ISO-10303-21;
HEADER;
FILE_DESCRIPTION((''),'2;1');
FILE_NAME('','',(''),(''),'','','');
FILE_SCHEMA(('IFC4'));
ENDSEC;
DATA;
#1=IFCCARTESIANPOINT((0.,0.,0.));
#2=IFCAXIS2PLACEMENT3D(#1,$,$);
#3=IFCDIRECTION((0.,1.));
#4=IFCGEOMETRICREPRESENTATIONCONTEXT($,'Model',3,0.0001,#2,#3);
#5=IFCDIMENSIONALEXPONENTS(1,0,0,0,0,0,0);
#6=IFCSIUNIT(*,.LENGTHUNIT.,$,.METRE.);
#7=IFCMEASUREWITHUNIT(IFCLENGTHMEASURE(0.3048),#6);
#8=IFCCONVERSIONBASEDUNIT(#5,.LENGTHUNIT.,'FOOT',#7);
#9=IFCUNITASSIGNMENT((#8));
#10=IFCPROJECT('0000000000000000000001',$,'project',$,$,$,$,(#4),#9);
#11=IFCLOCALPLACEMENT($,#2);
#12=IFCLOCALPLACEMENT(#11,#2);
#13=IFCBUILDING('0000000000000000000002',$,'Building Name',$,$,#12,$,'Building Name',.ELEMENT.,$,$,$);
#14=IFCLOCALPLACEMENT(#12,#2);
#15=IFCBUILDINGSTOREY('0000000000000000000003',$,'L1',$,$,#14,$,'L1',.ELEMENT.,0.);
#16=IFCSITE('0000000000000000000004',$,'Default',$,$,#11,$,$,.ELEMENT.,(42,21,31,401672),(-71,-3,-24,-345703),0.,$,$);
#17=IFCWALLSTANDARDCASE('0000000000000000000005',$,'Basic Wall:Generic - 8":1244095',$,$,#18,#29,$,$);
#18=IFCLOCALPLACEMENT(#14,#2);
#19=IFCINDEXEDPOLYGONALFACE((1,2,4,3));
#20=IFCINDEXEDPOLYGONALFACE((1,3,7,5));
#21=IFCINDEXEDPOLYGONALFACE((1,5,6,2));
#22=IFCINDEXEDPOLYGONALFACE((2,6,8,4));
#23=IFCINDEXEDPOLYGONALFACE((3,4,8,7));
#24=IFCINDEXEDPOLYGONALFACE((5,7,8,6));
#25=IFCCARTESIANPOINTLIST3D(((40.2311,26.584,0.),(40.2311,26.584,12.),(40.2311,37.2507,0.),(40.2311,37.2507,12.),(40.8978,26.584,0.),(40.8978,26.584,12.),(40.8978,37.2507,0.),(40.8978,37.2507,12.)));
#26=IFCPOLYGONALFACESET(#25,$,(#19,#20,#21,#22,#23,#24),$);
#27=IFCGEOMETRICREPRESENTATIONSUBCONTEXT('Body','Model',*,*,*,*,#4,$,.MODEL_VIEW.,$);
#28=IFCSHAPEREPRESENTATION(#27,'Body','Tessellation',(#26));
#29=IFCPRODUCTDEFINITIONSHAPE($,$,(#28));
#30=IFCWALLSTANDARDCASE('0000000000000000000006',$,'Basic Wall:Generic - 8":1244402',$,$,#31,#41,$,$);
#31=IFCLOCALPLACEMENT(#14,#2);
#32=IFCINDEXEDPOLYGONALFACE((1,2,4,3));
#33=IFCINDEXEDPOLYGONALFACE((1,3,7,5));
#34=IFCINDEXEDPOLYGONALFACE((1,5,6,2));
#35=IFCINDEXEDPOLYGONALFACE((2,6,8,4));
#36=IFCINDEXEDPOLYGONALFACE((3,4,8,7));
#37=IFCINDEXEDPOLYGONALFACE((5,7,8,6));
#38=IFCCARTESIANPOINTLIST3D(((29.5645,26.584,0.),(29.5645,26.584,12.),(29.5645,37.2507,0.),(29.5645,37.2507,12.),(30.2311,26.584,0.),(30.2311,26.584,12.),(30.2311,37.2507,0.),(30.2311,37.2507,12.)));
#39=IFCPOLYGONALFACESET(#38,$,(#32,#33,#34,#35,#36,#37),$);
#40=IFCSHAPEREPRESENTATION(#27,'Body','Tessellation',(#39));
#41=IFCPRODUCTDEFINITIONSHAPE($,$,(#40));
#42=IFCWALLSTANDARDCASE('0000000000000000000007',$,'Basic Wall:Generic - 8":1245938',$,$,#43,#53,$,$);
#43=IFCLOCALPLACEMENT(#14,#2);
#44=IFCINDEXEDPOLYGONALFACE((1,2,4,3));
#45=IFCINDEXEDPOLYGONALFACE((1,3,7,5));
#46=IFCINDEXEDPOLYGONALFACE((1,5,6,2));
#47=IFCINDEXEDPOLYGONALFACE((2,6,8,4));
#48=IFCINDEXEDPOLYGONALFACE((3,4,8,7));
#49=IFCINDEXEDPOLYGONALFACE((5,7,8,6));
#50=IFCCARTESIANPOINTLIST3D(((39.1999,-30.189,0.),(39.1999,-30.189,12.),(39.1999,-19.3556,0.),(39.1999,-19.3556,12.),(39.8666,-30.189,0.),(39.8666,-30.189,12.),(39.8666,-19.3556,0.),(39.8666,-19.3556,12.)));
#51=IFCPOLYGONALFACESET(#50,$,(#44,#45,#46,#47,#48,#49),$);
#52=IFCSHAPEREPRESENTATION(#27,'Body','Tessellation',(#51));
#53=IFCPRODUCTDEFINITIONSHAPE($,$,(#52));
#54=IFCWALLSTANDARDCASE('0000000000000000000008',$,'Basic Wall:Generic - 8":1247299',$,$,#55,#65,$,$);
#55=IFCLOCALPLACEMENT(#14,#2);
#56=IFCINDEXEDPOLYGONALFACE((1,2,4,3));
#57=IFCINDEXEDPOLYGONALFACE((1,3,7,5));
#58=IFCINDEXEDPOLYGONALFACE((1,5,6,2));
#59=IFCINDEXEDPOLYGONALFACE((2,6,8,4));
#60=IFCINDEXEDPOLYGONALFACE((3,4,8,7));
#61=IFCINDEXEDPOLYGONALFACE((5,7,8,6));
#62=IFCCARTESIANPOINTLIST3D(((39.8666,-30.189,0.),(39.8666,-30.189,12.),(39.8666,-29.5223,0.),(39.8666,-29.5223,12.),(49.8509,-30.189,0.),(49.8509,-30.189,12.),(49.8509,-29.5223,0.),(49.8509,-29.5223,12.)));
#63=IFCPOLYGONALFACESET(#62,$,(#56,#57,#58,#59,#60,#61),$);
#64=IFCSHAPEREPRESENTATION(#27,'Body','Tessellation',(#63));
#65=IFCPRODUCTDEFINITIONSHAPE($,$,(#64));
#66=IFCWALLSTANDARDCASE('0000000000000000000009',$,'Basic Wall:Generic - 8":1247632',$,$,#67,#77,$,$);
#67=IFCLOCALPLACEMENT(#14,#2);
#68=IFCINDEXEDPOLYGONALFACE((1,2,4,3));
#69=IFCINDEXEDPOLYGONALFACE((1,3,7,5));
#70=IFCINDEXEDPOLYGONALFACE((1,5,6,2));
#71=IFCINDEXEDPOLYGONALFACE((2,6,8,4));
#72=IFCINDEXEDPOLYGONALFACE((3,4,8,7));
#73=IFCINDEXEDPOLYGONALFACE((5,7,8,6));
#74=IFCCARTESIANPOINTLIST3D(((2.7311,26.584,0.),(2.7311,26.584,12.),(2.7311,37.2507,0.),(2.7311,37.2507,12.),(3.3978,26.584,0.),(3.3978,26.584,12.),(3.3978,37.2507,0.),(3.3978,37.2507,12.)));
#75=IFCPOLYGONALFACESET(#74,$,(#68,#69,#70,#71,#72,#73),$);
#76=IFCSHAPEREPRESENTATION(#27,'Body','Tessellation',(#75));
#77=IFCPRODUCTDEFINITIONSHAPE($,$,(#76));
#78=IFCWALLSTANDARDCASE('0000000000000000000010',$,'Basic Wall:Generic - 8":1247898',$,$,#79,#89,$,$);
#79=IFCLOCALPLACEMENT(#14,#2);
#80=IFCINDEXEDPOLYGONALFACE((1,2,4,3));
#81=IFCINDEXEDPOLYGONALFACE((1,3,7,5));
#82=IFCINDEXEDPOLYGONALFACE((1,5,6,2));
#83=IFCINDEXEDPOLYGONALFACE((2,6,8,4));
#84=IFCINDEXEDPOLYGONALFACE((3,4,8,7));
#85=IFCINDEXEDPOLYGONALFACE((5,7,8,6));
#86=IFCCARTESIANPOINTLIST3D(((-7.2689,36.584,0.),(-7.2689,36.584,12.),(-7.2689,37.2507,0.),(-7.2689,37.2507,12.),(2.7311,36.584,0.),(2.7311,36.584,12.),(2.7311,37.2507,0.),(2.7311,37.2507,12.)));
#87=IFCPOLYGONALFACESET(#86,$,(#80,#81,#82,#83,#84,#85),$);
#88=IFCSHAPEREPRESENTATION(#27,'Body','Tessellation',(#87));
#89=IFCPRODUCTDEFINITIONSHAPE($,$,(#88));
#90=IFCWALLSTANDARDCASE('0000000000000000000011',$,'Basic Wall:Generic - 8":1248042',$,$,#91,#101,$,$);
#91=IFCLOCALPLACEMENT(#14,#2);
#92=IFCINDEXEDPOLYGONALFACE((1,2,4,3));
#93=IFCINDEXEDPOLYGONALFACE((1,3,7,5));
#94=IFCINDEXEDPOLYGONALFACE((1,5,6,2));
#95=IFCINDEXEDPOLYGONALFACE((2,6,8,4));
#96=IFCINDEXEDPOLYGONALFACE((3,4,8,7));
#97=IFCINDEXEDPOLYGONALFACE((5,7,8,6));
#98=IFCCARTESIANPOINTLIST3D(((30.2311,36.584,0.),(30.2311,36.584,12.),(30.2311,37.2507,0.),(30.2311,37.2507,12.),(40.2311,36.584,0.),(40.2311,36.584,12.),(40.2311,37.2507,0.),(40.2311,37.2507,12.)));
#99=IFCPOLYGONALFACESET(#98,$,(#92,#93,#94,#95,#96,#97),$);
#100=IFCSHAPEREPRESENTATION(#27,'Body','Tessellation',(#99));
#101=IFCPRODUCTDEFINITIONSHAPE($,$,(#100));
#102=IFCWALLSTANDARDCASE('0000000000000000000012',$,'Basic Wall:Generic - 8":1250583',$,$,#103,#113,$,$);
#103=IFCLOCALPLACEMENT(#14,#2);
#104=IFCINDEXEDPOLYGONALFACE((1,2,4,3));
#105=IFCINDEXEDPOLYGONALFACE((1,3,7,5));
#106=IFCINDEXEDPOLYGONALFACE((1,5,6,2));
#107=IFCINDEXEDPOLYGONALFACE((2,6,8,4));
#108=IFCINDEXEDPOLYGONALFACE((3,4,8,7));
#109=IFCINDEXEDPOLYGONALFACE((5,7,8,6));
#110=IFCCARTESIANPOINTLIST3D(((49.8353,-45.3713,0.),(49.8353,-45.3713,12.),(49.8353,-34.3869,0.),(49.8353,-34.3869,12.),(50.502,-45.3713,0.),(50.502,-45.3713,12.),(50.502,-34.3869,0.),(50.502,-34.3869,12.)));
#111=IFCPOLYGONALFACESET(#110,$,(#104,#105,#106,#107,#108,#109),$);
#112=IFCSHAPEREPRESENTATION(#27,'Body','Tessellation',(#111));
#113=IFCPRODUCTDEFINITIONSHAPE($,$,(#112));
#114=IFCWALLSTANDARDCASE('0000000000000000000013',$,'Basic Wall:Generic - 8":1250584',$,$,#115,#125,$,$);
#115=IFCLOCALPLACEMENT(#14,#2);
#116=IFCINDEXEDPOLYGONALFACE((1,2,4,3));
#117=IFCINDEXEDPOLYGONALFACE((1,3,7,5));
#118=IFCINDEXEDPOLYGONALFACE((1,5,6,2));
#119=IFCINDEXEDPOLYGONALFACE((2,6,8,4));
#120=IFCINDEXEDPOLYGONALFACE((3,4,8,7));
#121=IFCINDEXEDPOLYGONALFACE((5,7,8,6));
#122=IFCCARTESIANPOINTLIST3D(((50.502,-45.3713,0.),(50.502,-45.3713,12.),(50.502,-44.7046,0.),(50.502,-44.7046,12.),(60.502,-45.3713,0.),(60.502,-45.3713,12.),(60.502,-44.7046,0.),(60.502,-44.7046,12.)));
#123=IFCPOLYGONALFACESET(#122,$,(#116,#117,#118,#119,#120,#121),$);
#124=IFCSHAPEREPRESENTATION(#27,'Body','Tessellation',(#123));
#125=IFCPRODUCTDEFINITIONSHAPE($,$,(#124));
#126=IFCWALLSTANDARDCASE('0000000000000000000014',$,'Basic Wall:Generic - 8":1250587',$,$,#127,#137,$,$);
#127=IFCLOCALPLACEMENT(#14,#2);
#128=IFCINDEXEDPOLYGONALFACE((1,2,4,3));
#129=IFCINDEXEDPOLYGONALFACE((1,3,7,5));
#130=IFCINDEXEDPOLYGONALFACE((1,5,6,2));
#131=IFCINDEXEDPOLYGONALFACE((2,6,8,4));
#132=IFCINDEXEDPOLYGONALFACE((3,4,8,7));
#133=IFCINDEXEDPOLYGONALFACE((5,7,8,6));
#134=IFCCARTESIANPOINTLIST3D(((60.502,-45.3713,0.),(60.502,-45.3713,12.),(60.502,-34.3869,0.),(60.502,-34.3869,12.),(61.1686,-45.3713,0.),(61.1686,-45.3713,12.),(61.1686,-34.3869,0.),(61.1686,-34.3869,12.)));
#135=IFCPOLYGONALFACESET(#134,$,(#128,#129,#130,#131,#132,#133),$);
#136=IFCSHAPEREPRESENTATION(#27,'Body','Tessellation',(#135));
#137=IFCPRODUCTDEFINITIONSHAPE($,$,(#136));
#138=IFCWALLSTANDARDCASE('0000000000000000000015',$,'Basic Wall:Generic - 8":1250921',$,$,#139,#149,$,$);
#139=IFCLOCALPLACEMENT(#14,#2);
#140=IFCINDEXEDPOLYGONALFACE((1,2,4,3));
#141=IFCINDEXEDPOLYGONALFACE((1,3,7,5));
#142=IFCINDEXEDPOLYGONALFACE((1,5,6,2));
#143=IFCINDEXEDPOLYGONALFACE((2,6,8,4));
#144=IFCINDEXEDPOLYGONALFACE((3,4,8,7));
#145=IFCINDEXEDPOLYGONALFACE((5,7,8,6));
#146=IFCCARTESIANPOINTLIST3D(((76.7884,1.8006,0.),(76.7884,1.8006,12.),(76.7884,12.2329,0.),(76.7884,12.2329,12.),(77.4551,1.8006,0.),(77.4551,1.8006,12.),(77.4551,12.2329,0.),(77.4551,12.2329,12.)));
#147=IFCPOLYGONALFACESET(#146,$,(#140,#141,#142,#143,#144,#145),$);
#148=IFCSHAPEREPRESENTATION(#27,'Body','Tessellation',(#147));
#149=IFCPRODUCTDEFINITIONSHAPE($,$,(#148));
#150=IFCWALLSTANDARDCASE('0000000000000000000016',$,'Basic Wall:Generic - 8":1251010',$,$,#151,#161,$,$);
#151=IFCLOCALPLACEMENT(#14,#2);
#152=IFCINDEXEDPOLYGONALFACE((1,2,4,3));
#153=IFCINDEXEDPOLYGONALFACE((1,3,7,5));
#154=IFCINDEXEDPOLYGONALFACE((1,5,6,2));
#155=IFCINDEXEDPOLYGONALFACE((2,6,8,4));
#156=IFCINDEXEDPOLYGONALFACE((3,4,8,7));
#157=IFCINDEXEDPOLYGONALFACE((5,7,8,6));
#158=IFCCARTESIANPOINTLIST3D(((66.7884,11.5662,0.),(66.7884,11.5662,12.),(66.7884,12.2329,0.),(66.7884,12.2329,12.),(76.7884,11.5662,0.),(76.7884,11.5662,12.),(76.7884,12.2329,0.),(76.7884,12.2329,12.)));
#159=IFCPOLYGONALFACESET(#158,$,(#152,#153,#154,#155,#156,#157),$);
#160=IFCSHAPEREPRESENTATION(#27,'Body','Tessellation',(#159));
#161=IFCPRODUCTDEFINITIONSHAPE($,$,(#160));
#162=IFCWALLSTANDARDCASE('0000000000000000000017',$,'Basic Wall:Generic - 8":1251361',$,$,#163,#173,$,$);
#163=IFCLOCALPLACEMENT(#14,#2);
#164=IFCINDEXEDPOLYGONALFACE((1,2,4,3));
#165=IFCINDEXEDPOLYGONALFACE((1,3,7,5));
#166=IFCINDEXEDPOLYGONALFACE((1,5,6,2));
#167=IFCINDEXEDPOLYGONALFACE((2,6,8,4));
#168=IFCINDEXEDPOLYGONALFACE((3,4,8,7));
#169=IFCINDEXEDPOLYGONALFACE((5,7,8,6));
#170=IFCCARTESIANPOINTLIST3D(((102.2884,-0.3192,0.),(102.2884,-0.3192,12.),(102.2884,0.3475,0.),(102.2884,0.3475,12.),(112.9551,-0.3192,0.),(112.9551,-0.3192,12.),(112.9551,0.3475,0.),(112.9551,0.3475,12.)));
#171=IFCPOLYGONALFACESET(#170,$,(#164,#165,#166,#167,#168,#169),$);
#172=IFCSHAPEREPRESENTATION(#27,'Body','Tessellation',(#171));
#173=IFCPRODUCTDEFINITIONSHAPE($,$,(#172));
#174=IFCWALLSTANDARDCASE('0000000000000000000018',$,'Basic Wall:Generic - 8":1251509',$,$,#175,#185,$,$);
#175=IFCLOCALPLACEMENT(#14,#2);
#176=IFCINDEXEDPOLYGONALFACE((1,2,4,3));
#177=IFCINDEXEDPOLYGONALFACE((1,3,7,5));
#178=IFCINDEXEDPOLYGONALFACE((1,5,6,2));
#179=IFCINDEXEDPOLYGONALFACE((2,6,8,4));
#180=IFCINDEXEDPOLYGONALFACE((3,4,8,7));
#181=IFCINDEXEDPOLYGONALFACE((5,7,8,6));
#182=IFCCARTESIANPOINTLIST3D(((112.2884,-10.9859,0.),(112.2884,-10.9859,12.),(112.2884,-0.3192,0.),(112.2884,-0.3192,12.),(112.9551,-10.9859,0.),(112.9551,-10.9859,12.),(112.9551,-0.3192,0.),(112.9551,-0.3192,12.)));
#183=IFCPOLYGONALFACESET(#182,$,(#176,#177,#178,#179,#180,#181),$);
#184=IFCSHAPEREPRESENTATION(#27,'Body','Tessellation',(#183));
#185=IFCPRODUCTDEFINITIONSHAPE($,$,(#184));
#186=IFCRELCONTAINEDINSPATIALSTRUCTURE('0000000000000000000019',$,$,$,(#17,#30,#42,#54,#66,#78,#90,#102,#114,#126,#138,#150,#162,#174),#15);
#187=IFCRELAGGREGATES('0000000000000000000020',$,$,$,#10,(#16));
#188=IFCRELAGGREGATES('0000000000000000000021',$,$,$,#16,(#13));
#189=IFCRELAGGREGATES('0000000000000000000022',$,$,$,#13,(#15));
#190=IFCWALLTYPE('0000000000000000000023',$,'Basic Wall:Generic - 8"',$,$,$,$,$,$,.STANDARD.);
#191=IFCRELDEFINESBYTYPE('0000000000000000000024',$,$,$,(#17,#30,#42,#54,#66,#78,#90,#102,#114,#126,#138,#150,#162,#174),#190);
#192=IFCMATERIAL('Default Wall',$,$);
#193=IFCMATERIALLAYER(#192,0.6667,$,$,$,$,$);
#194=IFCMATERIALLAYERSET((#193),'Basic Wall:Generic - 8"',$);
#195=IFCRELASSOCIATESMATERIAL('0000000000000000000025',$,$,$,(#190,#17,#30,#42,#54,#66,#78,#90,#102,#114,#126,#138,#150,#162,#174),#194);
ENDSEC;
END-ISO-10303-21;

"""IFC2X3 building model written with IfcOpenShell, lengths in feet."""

from ifc_helpers import new_model, entity, si_unit, converted_unit, direction, frame, frame_2d, origin, place, context, subcontext, project, spatial, rectangle, extrude, material, layer, layer_set, layer_usage, type_object, element, save


model = new_model("IFC2X3")

# Units and contexts
model_context = context("Model", 3, precision=0.0001, world=origin(), true_north=direction((0.0, 1.0)))
body_context = subcontext(model_context, "Body", "Model", "MODEL_VIEW")
ifc_project = project(units=[converted_unit("LENGTHUNIT", "FOOT", entity("IfcLengthMeasure", 0.3048), si_unit("LENGTHUNIT", "METRE"), dimensions=[1, 0, 0, 0, 0, 0, 0])], contexts=[model_context])

# Site, building, storey
site_placement = place(None, origin())
site = spatial("IfcSite", under=ifc_project, at=site_placement, Name="Default", CompositionType="ELEMENT", RefLatitude=(42, 21, 31, 401672), RefLongitude=(-71, -3, -24, -345703), RefElevation=0.0)
building_placement = place(site_placement, origin())
building = spatial("IfcBuilding", under=site, at=building_placement, Name="Building Name", LongName="Building Name", CompositionType="ELEMENT")
storey_placement = place(building_placement, origin())
storey = spatial("IfcBuildingStorey", under=building, at=storey_placement, Name="L1", LongName="L1", CompositionType="ELEMENT", Elevation=0.0)

# Walls
ifc_material_1 = material(Name="Default Wall")
ifc_layer_1 = layer(ifc_material_1, 0.6667)
ifc_layer_set_1 = layer_set([ifc_layer_1], Name="Basic Wall:Generic - 8\"")
ifc_layer_usage_1 = layer_usage(ifc_layer_set_1, "AXIS2", "POSITIVE", -0.3333)
wall_type_1 = type_object("IfcWallType", Name="Basic Wall:Generic - 8\"", PredefinedType="STANDARD", material=ifc_layer_set_1)
wall_1_placement = place(storey_placement, frame((40.5645, 26.584, 0.0), z_axis=(0.0, 0.0, 1.0), x_axis=(0.0, 1.0, 0.0)))
element("IfcWallStandardCase", 1, at=wall_1_placement, inside=storey, type_object=wall_type_1, material=ifc_layer_usage_1, Name="Basic Wall:Generic - 8\":1244095", context=body_context, shape_type="SweptSolid", body=[
    extrude(rectangle(XDim=10.6667, YDim=0.6667, at=frame_2d((5.3333, 0.0), x_axis=(-1.0, 0.0))), origin(), (0.0, 0.0, 1.0), 12.0),
])
ifc_layer_usage_2 = layer_usage(ifc_layer_set_1, "AXIS2", "NEGATIVE", 0.3333)
wall_2_placement = place(storey_placement, frame((29.8978, 26.584, 0.0), z_axis=(0.0, 0.0, 1.0), x_axis=(0.0, 1.0, 0.0)))
element("IfcWallStandardCase", 2, at=wall_2_placement, inside=storey, type_object=wall_type_1, material=ifc_layer_usage_2, Name="Basic Wall:Generic - 8\":1244402", context=body_context, shape_type="SweptSolid", body=[
    extrude(rectangle(XDim=10.6667, YDim=0.6667, at=frame_2d((5.3333, 0.0), x_axis=(-1.0, 0.0))), origin(), (0.0, 0.0, 1.0), 12.0),
])
ifc_layer_usage_3 = layer_usage(ifc_layer_set_1, "AXIS2", "POSITIVE", -0.3333)
wall_3_placement = place(storey_placement, frame((39.5332, -19.3556, 0.0), z_axis=(0.0, 0.0, 1.0), x_axis=(0.0, -1.0, 0.0)))
element("IfcWallStandardCase", 3, at=wall_3_placement, inside=storey, type_object=wall_type_1, material=ifc_layer_usage_3, Name="Basic Wall:Generic - 8\":1245938", context=body_context, shape_type="SweptSolid", body=[
    extrude(rectangle(XDim=10.8333, YDim=0.6667, at=frame_2d((5.4167, 0.0), x_axis=(-1.0, 0.0))), origin(), (0.0, 0.0, 1.0), 12.0),
])
ifc_layer_usage_4 = layer_usage(ifc_layer_set_1, "AXIS2", "NEGATIVE", 0.3333)
wall_4_placement = place(storey_placement, frame((39.8666, -29.8556, 0.0)))
element("IfcWallStandardCase", 4, at=wall_4_placement, inside=storey, type_object=wall_type_1, material=ifc_layer_usage_4, Name="Basic Wall:Generic - 8\":1247299", context=body_context, shape_type="SweptSolid", body=[
    extrude(rectangle(XDim=9.9844, YDim=0.6667, at=frame_2d((4.9922, 0.0), x_axis=(-1.0, 0.0))), origin(), (0.0, 0.0, 1.0), 12.0),
])
ifc_layer_usage_5 = layer_usage(ifc_layer_set_1, "AXIS2", "NEGATIVE", 0.3333)
wall_5_placement = place(storey_placement, frame((3.0645, 37.2507, 0.0), z_axis=(0.0, 0.0, 1.0), x_axis=(0.0, -1.0, 0.0)))
element("IfcWallStandardCase", 5, at=wall_5_placement, inside=storey, type_object=wall_type_1, material=ifc_layer_usage_5, Name="Basic Wall:Generic - 8\":1247632", context=body_context, shape_type="SweptSolid", body=[
    extrude(rectangle(XDim=10.6667, YDim=0.6667, at=frame_2d((5.3333, 0.0), x_axis=(-1.0, 0.0))), origin(), (0.0, 0.0, 1.0), 12.0),
])
ifc_layer_usage_6 = layer_usage(ifc_layer_set_1, "AXIS2", "NEGATIVE", 0.3333)
wall_6_placement = place(storey_placement, frame((-7.2689, 36.9174, 0.0)))
element("IfcWallStandardCase", 6, at=wall_6_placement, inside=storey, type_object=wall_type_1, material=ifc_layer_usage_6, Name="Basic Wall:Generic - 8\":1247898", context=body_context, shape_type="SweptSolid", body=[
    extrude(rectangle(XDim=10.0, YDim=0.6667, at=frame_2d((5.0, 0.0), x_axis=(-1.0, 0.0))), origin(), (0.0, 0.0, 1.0), 12.0),
])
ifc_layer_usage_7 = layer_usage(ifc_layer_set_1, "AXIS2", "NEGATIVE", 0.3333)
wall_7_placement = place(storey_placement, frame((30.2311, 36.9174, 0.0)))
element("IfcWallStandardCase", 7, at=wall_7_placement, inside=storey, type_object=wall_type_1, material=ifc_layer_usage_7, Name="Basic Wall:Generic - 8\":1248042", context=body_context, shape_type="SweptSolid", body=[
    extrude(rectangle(XDim=10.0, YDim=0.6667, at=frame_2d((5.0, 0.0), x_axis=(-1.0, 0.0))), origin(), (0.0, 0.0, 1.0), 12.0),
])
ifc_layer_usage_8 = layer_usage(ifc_layer_set_1, "AXIS2", "POSITIVE", -0.3333)
wall_8_placement = place(storey_placement, frame((50.1686, -34.3869, 0.0), z_axis=(0.0, 0.0, 1.0), x_axis=(0.0, -1.0, 0.0)))
element("IfcWallStandardCase", 8, at=wall_8_placement, inside=storey, type_object=wall_type_1, material=ifc_layer_usage_8, Name="Basic Wall:Generic - 8\":1250583", context=body_context, shape_type="SweptSolid", body=[
    extrude(rectangle(XDim=10.9844, YDim=0.6667, at=frame_2d((5.4922, 0.0), x_axis=(-1.0, 0.0))), origin(), (0.0, 0.0, 1.0), 12.0),
])
ifc_layer_usage_9 = layer_usage(ifc_layer_set_1, "AXIS2", "POSITIVE", -0.3333)
wall_9_placement = place(storey_placement, frame((50.502, -45.0379, 0.0)))
element("IfcWallStandardCase", 9, at=wall_9_placement, inside=storey, type_object=wall_type_1, material=ifc_layer_usage_9, Name="Basic Wall:Generic - 8\":1250584", context=body_context, shape_type="SweptSolid", body=[
    extrude(rectangle(XDim=10.0, YDim=0.6667, at=frame_2d((5.0, 0.0), x_axis=(-1.0, 0.0))), origin(), (0.0, 0.0, 1.0), 12.0),
])
ifc_layer_usage_10 = layer_usage(ifc_layer_set_1, "AXIS2", "NEGATIVE", 0.3333)
wall_10_placement = place(storey_placement, frame((60.8353, -34.3869, 0.0), z_axis=(0.0, 0.0, 1.0), x_axis=(0.0, -1.0, 0.0)))
element("IfcWallStandardCase", 10, at=wall_10_placement, inside=storey, type_object=wall_type_1, material=ifc_layer_usage_10, Name="Basic Wall:Generic - 8\":1250587", context=body_context, shape_type="SweptSolid", body=[
    extrude(rectangle(XDim=10.9844, YDim=0.6667, at=frame_2d((5.4922, 0.0), x_axis=(-1.0, 0.0))), origin(), (0.0, 0.0, 1.0), 12.0),
])
ifc_layer_usage_11 = layer_usage(ifc_layer_set_1, "AXIS2", "NEGATIVE", 0.3333)
wall_11_placement = place(storey_placement, frame((77.1218, 1.8006, 0.0), z_axis=(0.0, 0.0, 1.0), x_axis=(0.0, 1.0, 0.0)))
element("IfcWallStandardCase", 11, at=wall_11_placement, inside=storey, type_object=wall_type_1, material=ifc_layer_usage_11, Name="Basic Wall:Generic - 8\":1250921", context=body_context, shape_type="SweptSolid", body=[
    extrude(rectangle(XDim=10.4323, YDim=0.6667, at=frame_2d((5.2161, 0.0), x_axis=(-1.0, 0.0))), origin(), (0.0, 0.0, 1.0), 12.0),
])
ifc_layer_usage_12 = layer_usage(ifc_layer_set_1, "AXIS2", "NEGATIVE", 0.3333)
wall_12_placement = place(storey_placement, frame((76.7884, 11.8996, 0.0), z_axis=(0.0, 0.0, 1.0), x_axis=(-1.0, 0.0, 0.0)))
element("IfcWallStandardCase", 12, at=wall_12_placement, inside=storey, type_object=wall_type_1, material=ifc_layer_usage_12, Name="Basic Wall:Generic - 8\":1251010", context=body_context, shape_type="SweptSolid", body=[
    extrude(rectangle(XDim=10.0, YDim=0.6667, at=frame_2d((5.0, 0.0), x_axis=(-1.0, 0.0))), origin(), (0.0, 0.0, 1.0), 12.0),
])
ifc_layer_usage_13 = layer_usage(ifc_layer_set_1, "AXIS2", "NEGATIVE", 0.3333)
wall_13_placement = place(storey_placement, frame((102.2884, 0.0141, 0.0)))
element("IfcWallStandardCase", 13, at=wall_13_placement, inside=storey, type_object=wall_type_1, material=ifc_layer_usage_13, Name="Basic Wall:Generic - 8\":1251361", context=body_context, shape_type="SweptSolid", body=[
    extrude(rectangle(XDim=10.6667, YDim=0.6667, at=frame_2d((5.3333, 0.0), x_axis=(-1.0, 0.0))), origin(), (0.0, 0.0, 1.0), 12.0),
])
ifc_layer_usage_14 = layer_usage(ifc_layer_set_1, "AXIS2", "POSITIVE", -0.3333)
wall_14_placement = place(storey_placement, frame((112.6218, -0.3192, 0.0), z_axis=(0.0, 0.0, 1.0), x_axis=(0.0, -1.0, 0.0)))
element("IfcWallStandardCase", 14, at=wall_14_placement, inside=storey, type_object=wall_type_1, material=ifc_layer_usage_14, Name="Basic Wall:Generic - 8\":1251509", context=body_context, shape_type="SweptSolid", body=[
    extrude(rectangle(XDim=10.6667, YDim=0.6667, at=frame_2d((5.3333, 0.0), x_axis=(-1.0, 0.0))), origin(), (0.0, 0.0, 1.0), 12.0),
])

save(model, "model.ifc")
